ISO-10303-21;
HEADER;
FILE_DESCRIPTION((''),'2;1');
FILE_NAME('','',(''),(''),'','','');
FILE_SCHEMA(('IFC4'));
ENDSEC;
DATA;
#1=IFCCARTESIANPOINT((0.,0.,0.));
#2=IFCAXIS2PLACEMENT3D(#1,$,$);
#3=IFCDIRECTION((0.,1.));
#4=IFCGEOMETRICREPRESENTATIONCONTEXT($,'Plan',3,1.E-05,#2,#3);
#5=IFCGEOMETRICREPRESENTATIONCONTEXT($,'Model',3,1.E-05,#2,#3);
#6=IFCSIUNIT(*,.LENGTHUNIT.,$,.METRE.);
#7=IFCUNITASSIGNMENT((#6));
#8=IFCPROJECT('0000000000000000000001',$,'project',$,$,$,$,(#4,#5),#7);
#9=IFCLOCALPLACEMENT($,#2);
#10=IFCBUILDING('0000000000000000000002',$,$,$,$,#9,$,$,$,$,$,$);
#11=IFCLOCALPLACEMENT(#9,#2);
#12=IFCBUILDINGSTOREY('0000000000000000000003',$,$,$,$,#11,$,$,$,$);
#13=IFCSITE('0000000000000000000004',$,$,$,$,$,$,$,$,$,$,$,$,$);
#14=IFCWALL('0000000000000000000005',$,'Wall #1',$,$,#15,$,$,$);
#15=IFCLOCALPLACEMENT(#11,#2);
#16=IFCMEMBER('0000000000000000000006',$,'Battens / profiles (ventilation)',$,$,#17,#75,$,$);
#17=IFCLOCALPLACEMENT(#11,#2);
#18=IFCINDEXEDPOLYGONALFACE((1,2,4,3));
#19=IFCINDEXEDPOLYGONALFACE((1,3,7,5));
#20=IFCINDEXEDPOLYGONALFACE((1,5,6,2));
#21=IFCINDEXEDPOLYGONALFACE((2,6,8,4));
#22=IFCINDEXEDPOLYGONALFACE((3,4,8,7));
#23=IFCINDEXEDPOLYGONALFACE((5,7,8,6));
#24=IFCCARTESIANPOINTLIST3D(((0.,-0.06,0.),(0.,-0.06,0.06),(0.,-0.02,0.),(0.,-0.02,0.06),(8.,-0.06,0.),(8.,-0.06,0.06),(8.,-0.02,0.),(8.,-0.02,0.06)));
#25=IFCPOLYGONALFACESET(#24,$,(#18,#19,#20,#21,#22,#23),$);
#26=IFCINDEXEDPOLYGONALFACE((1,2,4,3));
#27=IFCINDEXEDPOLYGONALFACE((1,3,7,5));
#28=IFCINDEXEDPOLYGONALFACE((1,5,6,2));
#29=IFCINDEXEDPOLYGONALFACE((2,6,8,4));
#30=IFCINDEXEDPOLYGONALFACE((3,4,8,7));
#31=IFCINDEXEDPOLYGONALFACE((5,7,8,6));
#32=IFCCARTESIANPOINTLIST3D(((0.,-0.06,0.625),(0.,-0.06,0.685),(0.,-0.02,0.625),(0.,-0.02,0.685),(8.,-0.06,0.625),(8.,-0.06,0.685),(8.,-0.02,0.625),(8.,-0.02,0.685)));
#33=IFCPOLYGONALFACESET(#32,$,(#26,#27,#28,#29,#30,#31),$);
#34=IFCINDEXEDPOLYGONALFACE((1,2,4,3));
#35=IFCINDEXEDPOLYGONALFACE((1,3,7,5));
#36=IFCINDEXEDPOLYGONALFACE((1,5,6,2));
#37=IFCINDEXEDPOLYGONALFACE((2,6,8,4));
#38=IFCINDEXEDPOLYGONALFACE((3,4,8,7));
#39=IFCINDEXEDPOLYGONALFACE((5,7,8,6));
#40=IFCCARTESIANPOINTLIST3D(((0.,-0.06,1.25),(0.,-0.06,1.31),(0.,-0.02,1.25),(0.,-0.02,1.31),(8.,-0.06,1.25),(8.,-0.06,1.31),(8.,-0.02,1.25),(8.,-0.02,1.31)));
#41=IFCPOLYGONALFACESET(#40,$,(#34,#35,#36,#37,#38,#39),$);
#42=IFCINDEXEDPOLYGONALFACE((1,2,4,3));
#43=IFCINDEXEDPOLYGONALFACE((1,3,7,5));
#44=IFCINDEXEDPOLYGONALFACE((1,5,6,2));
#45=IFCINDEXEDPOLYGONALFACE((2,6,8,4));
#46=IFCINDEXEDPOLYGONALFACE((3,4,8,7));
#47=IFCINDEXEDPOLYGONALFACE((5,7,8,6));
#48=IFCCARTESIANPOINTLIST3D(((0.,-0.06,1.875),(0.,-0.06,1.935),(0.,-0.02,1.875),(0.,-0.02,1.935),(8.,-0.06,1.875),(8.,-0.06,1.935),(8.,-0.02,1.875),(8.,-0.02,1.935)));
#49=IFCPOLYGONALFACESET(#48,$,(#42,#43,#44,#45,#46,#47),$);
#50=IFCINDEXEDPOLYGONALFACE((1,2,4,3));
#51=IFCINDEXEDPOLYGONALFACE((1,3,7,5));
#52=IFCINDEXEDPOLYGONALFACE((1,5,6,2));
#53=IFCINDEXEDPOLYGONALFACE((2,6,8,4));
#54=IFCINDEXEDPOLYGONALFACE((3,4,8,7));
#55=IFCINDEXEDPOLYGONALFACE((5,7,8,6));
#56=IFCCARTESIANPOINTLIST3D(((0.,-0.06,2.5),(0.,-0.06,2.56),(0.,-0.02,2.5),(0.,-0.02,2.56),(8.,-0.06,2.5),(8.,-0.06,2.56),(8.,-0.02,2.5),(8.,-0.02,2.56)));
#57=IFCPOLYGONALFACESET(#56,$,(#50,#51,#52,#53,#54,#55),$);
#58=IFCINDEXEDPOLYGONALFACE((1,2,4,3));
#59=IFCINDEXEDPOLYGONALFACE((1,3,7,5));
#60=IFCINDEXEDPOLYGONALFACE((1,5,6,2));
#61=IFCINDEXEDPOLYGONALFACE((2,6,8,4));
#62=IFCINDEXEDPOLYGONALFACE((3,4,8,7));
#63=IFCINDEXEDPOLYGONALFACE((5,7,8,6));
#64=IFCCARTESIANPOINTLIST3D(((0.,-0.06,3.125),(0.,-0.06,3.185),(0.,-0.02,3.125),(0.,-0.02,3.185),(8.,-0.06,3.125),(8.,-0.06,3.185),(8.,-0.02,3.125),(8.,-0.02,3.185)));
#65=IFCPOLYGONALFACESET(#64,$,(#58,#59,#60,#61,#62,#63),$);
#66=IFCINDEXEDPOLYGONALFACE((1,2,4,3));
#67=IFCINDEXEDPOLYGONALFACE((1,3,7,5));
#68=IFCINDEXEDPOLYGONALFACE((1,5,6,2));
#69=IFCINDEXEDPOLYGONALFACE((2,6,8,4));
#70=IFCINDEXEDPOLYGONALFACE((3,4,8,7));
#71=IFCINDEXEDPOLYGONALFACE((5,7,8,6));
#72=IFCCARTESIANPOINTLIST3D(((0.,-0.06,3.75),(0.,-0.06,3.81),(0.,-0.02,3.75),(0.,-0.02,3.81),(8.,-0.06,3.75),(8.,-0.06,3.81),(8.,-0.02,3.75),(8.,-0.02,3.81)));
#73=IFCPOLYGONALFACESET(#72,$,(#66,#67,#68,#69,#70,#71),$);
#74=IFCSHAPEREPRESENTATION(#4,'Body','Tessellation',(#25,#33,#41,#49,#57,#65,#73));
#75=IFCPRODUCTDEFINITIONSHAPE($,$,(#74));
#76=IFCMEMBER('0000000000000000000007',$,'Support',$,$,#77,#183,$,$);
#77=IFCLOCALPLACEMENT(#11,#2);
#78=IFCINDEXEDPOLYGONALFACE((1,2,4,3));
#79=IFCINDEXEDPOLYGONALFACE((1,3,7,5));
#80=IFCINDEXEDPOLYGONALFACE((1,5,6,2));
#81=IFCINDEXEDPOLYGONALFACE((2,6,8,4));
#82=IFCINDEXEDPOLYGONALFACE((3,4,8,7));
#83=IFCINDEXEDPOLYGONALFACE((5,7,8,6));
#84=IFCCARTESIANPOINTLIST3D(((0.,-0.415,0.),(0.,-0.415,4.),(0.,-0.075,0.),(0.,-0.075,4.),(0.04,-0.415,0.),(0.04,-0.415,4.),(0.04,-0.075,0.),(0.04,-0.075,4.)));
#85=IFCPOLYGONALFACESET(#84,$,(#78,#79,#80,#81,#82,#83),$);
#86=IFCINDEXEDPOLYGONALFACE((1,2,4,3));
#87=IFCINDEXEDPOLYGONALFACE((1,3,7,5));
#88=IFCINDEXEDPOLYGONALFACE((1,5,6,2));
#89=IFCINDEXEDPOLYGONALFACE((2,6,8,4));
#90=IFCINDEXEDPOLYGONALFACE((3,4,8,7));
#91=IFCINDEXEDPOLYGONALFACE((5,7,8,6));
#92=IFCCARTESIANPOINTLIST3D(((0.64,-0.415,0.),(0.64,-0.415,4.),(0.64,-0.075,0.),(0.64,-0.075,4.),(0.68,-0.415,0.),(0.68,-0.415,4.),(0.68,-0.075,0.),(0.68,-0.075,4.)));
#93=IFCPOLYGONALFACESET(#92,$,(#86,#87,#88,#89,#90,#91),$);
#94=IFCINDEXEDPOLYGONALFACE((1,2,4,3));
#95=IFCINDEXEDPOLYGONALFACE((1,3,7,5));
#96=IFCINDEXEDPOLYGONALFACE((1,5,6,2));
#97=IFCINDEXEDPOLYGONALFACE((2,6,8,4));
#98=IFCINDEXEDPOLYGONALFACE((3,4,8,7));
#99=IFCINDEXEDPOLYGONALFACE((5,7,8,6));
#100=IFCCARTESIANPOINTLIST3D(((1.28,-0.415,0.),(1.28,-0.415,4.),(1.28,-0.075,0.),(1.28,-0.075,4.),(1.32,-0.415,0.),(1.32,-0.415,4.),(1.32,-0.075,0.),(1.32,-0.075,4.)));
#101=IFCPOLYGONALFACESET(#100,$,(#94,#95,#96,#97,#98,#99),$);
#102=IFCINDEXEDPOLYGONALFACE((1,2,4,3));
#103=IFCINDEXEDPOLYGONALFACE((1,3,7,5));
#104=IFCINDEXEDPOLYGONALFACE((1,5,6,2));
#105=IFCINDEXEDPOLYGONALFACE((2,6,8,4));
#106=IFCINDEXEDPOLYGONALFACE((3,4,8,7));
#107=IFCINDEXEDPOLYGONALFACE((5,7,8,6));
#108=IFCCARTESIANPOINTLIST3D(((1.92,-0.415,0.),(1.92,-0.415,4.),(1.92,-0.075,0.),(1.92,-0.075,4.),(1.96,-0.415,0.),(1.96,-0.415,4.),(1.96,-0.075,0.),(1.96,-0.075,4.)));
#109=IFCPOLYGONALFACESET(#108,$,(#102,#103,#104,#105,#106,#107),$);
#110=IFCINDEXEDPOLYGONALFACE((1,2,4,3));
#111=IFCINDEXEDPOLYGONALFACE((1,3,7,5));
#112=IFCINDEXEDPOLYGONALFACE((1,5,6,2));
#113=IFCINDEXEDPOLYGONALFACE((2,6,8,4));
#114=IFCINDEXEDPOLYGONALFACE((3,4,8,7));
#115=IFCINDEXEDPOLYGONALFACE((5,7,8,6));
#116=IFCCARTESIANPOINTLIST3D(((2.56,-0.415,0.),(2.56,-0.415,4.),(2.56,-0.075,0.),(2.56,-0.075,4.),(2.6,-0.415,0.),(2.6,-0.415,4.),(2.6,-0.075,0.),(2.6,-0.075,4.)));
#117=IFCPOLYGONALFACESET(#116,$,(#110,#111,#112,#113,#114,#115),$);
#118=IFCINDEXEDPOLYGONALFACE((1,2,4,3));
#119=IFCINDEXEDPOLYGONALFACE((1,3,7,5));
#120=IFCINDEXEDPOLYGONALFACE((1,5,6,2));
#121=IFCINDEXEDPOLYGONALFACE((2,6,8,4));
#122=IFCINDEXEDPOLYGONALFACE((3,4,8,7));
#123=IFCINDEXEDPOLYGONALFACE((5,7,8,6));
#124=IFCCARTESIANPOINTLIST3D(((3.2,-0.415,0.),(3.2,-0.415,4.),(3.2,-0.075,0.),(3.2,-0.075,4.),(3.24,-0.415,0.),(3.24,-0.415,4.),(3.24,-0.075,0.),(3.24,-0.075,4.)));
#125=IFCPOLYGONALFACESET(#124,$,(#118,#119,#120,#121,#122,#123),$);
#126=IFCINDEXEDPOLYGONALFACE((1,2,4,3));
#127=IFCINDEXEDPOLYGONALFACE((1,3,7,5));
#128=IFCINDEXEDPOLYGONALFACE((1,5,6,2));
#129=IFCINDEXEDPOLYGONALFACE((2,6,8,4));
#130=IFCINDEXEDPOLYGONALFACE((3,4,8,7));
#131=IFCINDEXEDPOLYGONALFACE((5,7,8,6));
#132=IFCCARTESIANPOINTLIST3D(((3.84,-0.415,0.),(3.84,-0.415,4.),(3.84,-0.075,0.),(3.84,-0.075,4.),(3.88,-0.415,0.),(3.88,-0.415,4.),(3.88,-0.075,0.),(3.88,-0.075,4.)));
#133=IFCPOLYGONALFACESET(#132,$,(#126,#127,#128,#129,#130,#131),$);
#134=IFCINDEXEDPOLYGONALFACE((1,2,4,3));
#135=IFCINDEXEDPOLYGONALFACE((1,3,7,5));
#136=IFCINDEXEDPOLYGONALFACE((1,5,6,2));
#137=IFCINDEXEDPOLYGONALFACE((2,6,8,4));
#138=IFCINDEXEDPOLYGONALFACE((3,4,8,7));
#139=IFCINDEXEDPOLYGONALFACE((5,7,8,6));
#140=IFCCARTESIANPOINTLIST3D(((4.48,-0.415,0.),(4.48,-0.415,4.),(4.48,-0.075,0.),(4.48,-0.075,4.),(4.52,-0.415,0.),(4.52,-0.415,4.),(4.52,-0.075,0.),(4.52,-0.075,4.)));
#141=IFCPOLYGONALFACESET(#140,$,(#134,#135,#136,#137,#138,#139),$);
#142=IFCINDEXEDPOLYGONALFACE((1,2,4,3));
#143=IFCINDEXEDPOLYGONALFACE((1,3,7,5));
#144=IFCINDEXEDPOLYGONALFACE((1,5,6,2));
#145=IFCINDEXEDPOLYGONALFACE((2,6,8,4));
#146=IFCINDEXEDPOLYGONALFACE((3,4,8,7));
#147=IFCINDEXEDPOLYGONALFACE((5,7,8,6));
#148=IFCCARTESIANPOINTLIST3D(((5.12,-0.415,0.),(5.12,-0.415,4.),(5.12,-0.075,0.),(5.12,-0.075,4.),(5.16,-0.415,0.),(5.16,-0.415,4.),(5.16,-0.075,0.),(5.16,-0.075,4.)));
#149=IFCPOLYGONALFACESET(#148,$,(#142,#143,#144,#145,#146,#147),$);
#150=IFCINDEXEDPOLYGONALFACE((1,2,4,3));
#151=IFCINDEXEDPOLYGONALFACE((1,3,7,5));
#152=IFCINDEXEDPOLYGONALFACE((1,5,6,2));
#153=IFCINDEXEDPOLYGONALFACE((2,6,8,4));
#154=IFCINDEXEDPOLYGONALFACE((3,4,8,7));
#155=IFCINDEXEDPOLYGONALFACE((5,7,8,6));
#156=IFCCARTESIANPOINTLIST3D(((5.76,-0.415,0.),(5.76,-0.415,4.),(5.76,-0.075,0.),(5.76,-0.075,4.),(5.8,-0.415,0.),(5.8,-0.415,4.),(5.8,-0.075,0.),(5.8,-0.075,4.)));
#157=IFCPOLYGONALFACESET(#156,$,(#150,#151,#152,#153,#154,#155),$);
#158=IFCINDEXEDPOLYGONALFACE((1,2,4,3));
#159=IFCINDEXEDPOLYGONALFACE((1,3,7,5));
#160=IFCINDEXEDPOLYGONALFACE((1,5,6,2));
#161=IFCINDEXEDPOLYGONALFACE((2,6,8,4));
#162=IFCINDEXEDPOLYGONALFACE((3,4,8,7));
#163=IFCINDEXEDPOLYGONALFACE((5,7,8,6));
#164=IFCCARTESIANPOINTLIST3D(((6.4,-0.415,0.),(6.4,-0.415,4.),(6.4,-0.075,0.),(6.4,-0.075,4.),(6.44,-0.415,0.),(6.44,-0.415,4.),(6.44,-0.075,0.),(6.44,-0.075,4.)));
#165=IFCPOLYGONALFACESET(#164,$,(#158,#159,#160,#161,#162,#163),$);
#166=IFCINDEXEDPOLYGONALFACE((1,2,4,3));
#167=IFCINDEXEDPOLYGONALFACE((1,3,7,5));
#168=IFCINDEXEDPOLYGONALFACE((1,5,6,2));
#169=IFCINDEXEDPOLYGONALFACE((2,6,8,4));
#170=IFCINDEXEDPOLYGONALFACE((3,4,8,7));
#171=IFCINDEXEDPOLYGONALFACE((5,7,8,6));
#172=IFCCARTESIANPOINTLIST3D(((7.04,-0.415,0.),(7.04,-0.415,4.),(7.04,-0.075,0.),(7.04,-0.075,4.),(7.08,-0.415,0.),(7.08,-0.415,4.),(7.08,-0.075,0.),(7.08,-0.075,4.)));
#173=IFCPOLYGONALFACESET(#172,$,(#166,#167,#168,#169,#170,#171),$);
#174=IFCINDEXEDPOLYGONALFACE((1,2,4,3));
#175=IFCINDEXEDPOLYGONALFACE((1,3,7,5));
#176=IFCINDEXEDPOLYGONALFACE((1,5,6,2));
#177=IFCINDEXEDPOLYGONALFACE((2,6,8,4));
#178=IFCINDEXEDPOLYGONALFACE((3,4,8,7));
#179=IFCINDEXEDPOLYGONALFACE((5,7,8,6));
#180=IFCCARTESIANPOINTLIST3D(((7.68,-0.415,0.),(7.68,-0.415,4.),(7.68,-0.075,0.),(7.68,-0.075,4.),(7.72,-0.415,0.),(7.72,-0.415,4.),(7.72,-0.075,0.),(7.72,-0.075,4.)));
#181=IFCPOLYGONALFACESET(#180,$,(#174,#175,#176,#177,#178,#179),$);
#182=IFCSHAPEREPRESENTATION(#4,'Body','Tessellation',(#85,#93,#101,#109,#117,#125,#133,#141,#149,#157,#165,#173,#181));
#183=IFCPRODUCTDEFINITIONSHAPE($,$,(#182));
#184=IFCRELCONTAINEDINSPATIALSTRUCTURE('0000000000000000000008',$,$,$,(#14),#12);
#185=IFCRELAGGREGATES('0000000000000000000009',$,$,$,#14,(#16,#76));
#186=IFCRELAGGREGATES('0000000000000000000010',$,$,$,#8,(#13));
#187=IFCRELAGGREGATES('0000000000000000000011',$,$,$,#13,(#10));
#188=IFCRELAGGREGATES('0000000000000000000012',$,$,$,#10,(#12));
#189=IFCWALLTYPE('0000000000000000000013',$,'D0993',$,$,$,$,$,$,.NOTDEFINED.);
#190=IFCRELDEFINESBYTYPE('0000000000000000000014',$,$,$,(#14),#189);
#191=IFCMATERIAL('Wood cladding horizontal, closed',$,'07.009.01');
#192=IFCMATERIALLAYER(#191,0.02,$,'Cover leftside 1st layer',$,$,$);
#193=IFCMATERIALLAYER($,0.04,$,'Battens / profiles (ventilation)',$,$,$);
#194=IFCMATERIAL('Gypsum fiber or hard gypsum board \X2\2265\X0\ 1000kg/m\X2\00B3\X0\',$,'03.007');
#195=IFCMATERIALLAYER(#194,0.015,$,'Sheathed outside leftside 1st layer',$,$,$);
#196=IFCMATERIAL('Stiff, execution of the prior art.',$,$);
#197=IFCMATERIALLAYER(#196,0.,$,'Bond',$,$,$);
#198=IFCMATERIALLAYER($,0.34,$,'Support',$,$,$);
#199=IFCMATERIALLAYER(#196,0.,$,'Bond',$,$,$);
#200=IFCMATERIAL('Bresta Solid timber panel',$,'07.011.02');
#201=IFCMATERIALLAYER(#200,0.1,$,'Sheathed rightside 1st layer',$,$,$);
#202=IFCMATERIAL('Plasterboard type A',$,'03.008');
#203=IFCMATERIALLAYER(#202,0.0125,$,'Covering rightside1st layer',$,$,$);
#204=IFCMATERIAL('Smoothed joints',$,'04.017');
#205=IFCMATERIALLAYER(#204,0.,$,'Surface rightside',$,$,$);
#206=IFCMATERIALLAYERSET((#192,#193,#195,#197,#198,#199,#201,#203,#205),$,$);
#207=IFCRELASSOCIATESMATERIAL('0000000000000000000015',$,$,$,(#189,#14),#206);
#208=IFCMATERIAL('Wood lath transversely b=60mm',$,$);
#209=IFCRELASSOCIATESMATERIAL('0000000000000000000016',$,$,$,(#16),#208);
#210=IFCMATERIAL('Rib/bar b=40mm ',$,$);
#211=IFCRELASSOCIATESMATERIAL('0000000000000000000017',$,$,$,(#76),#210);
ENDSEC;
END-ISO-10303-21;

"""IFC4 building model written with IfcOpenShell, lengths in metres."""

from ifc_helpers import new_model, si_unit, direction, frame, frame_2d, origin, place, context, project, spatial, rectangle, extrude, material, layer, layer_set, type_object, element, aggregate, save


model = new_model("IFC4")

# Units and contexts
plan_context = context("Plan", 3, precision=1e-05, world=origin(), true_north=direction((0.0, 1.0)))
model_context = context("Model", 3, precision=1e-05, world=origin(), true_north=direction((0.0, 1.0)))
ifc_project = project(units=[si_unit("LENGTHUNIT", "METRE")], contexts=[plan_context, model_context])

# Site, building, storey
site = spatial("IfcSite", under=ifc_project)
building_placement = place(None, origin())
building = spatial("IfcBuilding", under=site, at=building_placement)
storey_placement = place(building_placement, origin())
storey = spatial("IfcBuildingStorey", under=building, at=storey_placement)

# Wall, members
ifc_material_1 = material(Name="Wood cladding horizontal, closed", Category="07.009.01")
ifc_layer_1 = layer(ifc_material_1, 0.02, Name="Cover leftside 1st layer")
ifc_layer_2 = layer(None, 0.04, Name="Battens / profiles (ventilation)")
ifc_material_2 = material(Name="Gypsum fiber or hard gypsum board ≥ 1000kg/m³", Category="03.007")
ifc_layer_3 = layer(ifc_material_2, 0.015, Name="Sheathed outside leftside 1st layer")
ifc_material_3 = material(Name="Stiff, execution of the prior art.")
ifc_layer_4 = layer(ifc_material_3, 0.0, Name="Bond")
ifc_layer_5 = layer(None, 0.34, Name="Support")
ifc_layer_6 = layer(ifc_material_3, 0.0, Name="Bond")
ifc_material_4 = material(Name="Bresta Solid timber panel", Category="07.011.02")
ifc_layer_7 = layer(ifc_material_4, 0.1, Name="Sheathed rightside 1st layer")
ifc_material_5 = material(Name="Plasterboard type A", Category="03.008")
ifc_layer_8 = layer(ifc_material_5, 0.0125, Name="Covering rightside1st layer")
ifc_material_6 = material(Name="Smoothed joints", Category="04.017")
ifc_layer_9 = layer(ifc_material_6, 0.0, Name="Surface rightside")
ifc_layer_set = layer_set([ifc_layer_1, ifc_layer_2, ifc_layer_3, ifc_layer_4, ifc_layer_5, ifc_layer_6, ifc_layer_7, ifc_layer_8, ifc_layer_9])
wall_type = type_object("IfcWallType", Name="D0993", PredefinedType="NOTDEFINED", material=ifc_layer_set)
wall_placement = place(None, frame((0.0, 0.0, 0.0), z_axis=(0.0, -1.0, 0.0), x_axis=(1.0, 0.0, 0.0)))
wall = element("IfcWall", 1, at=wall_placement, inside=storey, type_object=wall_type, material=ifc_layer_set, Name="Wall #1")
ifc_material_7 = material(Name="Wood lath transversely b=60mm")
member_1_placement = place(wall_placement, origin())
member_1 = element("IfcMember", 2, at=member_1_placement, material=ifc_material_7, Name="Battens / profiles (ventilation)", context=plan_context, shape_type="SweptSolid", body=[
    extrude(rectangle(XDim=0.06, YDim=0.04, at=frame_2d((0.03, 0.02), x_axis=(1.0, 0.0))), frame((0.0, 0.0, 0.02), z_axis=(1.0, 0.0, 0.0), x_axis=(0.0, 1.0, 0.0)), (0.0, 0.0, 1.0), 8.0),
    extrude(rectangle(XDim=0.06, YDim=0.04, at=frame_2d((0.03, 0.02), x_axis=(1.0, 0.0))), frame((0.0, 0.625, 0.02), z_axis=(1.0, 0.0, 0.0), x_axis=(0.0, 1.0, 0.0)), (0.0, 0.0, 1.0), 8.0),
    extrude(rectangle(XDim=0.06, YDim=0.04, at=frame_2d((0.03, 0.02), x_axis=(1.0, 0.0))), frame((0.0, 1.25, 0.02), z_axis=(1.0, 0.0, 0.0), x_axis=(0.0, 1.0, 0.0)), (0.0, 0.0, 1.0), 8.0),
    extrude(rectangle(XDim=0.06, YDim=0.04, at=frame_2d((0.03, 0.02), x_axis=(1.0, 0.0))), frame((0.0, 1.875, 0.02), z_axis=(1.0, 0.0, 0.0), x_axis=(0.0, 1.0, 0.0)), (0.0, 0.0, 1.0), 8.0),
    extrude(rectangle(XDim=0.06, YDim=0.04, at=frame_2d((0.03, 0.02), x_axis=(1.0, 0.0))), frame((0.0, 2.5, 0.02), z_axis=(1.0, 0.0, 0.0), x_axis=(0.0, 1.0, 0.0)), (0.0, 0.0, 1.0), 8.0),
    extrude(rectangle(XDim=0.06, YDim=0.04, at=frame_2d((0.03, 0.02), x_axis=(1.0, 0.0))), frame((0.0, 3.125, 0.02), z_axis=(1.0, 0.0, 0.0), x_axis=(0.0, 1.0, 0.0)), (0.0, 0.0, 1.0), 8.0),
    extrude(rectangle(XDim=0.06, YDim=0.04, at=frame_2d((0.03, 0.02), x_axis=(1.0, 0.0))), frame((0.0, 3.75, 0.02), z_axis=(1.0, 0.0, 0.0), x_axis=(0.0, 1.0, 0.0)), (0.0, 0.0, 1.0), 8.0),
])
ifc_material_8 = material(Name="Rib/bar b=40mm ")
member_2_placement = place(wall_placement, origin())
member_2 = element("IfcMember", 3, at=member_2_placement, material=ifc_material_8, Name="Support", context=plan_context, shape_type="SweptSolid", body=[
    extrude(rectangle(XDim=0.04, YDim=0.34, at=frame_2d((0.02, 0.17), x_axis=(1.0, 0.0))), frame((0.0, 4.0, 0.075), z_axis=(0.0, -1.0, 0.0), x_axis=(1.0, 0.0, 0.0)), (0.0, 0.0, 1.0), 4.0),
    extrude(rectangle(XDim=0.04, YDim=0.34, at=frame_2d((0.02, 0.17), x_axis=(1.0, 0.0))), frame((0.64, 4.0, 0.075), z_axis=(0.0, -1.0, 0.0), x_axis=(1.0, 0.0, 0.0)), (0.0, 0.0, 1.0), 4.0),
    extrude(rectangle(XDim=0.04, YDim=0.34, at=frame_2d((0.02, 0.17), x_axis=(1.0, 0.0))), frame((1.28, 4.0, 0.075), z_axis=(0.0, -1.0, 0.0), x_axis=(1.0, 0.0, 0.0)), (0.0, 0.0, 1.0), 4.0),
    extrude(rectangle(XDim=0.04, YDim=0.34, at=frame_2d((0.02, 0.17), x_axis=(1.0, 0.0))), frame((1.92, 4.0, 0.075), z_axis=(0.0, -1.0, 0.0), x_axis=(1.0, 0.0, 0.0)), (0.0, 0.0, 1.0), 4.0),
    extrude(rectangle(XDim=0.04, YDim=0.34, at=frame_2d((0.02, 0.17), x_axis=(1.0, 0.0))), frame((2.56, 4.0, 0.075), z_axis=(0.0, -1.0, 0.0), x_axis=(1.0, 0.0, 0.0)), (0.0, 0.0, 1.0), 4.0),
    extrude(rectangle(XDim=0.04, YDim=0.34, at=frame_2d((0.02, 0.17), x_axis=(1.0, 0.0))), frame((3.2, 4.0, 0.075), z_axis=(0.0, -1.0, 0.0), x_axis=(1.0, 0.0, 0.0)), (0.0, 0.0, 1.0), 4.0),
    extrude(rectangle(XDim=0.04, YDim=0.34, at=frame_2d((0.02, 0.17), x_axis=(1.0, 0.0))), frame((3.84, 4.0, 0.075), z_axis=(0.0, -1.0, 0.0), x_axis=(1.0, 0.0, 0.0)), (0.0, 0.0, 1.0), 4.0),
    extrude(rectangle(XDim=0.04, YDim=0.34, at=frame_2d((0.02, 0.17), x_axis=(1.0, 0.0))), frame((4.48, 4.0, 0.075), z_axis=(0.0, -1.0, 0.0), x_axis=(1.0, 0.0, 0.0)), (0.0, 0.0, 1.0), 4.0),
    extrude(rectangle(XDim=0.04, YDim=0.34, at=frame_2d((0.02, 0.17), x_axis=(1.0, 0.0))), frame((5.12, 4.0, 0.075), z_axis=(0.0, -1.0, 0.0), x_axis=(1.0, 0.0, 0.0)), (0.0, 0.0, 1.0), 4.0),
    extrude(rectangle(XDim=0.04, YDim=0.34, at=frame_2d((0.02, 0.17), x_axis=(1.0, 0.0))), frame((5.76, 4.0, 0.075), z_axis=(0.0, -1.0, 0.0), x_axis=(1.0, 0.0, 0.0)), (0.0, 0.0, 1.0), 4.0),
    extrude(rectangle(XDim=0.04, YDim=0.34, at=frame_2d((0.02, 0.17), x_axis=(1.0, 0.0))), frame((6.4, 4.0, 0.075), z_axis=(0.0, -1.0, 0.0), x_axis=(1.0, 0.0, 0.0)), (0.0, 0.0, 1.0), 4.0),
    extrude(rectangle(XDim=0.04, YDim=0.34, at=frame_2d((0.02, 0.17), x_axis=(1.0, 0.0))), frame((7.04, 4.0, 0.075), z_axis=(0.0, -1.0, 0.0), x_axis=(1.0, 0.0, 0.0)), (0.0, 0.0, 1.0), 4.0),
    extrude(rectangle(XDim=0.04, YDim=0.34, at=frame_2d((0.02, 0.17), x_axis=(1.0, 0.0))), frame((7.68, 4.0, 0.075), z_axis=(0.0, -1.0, 0.0), x_axis=(1.0, 0.0, 0.0)), (0.0, 0.0, 1.0), 4.0),
])
aggregate(wall, [member_1, member_2])

save(model, "model.ifc")
